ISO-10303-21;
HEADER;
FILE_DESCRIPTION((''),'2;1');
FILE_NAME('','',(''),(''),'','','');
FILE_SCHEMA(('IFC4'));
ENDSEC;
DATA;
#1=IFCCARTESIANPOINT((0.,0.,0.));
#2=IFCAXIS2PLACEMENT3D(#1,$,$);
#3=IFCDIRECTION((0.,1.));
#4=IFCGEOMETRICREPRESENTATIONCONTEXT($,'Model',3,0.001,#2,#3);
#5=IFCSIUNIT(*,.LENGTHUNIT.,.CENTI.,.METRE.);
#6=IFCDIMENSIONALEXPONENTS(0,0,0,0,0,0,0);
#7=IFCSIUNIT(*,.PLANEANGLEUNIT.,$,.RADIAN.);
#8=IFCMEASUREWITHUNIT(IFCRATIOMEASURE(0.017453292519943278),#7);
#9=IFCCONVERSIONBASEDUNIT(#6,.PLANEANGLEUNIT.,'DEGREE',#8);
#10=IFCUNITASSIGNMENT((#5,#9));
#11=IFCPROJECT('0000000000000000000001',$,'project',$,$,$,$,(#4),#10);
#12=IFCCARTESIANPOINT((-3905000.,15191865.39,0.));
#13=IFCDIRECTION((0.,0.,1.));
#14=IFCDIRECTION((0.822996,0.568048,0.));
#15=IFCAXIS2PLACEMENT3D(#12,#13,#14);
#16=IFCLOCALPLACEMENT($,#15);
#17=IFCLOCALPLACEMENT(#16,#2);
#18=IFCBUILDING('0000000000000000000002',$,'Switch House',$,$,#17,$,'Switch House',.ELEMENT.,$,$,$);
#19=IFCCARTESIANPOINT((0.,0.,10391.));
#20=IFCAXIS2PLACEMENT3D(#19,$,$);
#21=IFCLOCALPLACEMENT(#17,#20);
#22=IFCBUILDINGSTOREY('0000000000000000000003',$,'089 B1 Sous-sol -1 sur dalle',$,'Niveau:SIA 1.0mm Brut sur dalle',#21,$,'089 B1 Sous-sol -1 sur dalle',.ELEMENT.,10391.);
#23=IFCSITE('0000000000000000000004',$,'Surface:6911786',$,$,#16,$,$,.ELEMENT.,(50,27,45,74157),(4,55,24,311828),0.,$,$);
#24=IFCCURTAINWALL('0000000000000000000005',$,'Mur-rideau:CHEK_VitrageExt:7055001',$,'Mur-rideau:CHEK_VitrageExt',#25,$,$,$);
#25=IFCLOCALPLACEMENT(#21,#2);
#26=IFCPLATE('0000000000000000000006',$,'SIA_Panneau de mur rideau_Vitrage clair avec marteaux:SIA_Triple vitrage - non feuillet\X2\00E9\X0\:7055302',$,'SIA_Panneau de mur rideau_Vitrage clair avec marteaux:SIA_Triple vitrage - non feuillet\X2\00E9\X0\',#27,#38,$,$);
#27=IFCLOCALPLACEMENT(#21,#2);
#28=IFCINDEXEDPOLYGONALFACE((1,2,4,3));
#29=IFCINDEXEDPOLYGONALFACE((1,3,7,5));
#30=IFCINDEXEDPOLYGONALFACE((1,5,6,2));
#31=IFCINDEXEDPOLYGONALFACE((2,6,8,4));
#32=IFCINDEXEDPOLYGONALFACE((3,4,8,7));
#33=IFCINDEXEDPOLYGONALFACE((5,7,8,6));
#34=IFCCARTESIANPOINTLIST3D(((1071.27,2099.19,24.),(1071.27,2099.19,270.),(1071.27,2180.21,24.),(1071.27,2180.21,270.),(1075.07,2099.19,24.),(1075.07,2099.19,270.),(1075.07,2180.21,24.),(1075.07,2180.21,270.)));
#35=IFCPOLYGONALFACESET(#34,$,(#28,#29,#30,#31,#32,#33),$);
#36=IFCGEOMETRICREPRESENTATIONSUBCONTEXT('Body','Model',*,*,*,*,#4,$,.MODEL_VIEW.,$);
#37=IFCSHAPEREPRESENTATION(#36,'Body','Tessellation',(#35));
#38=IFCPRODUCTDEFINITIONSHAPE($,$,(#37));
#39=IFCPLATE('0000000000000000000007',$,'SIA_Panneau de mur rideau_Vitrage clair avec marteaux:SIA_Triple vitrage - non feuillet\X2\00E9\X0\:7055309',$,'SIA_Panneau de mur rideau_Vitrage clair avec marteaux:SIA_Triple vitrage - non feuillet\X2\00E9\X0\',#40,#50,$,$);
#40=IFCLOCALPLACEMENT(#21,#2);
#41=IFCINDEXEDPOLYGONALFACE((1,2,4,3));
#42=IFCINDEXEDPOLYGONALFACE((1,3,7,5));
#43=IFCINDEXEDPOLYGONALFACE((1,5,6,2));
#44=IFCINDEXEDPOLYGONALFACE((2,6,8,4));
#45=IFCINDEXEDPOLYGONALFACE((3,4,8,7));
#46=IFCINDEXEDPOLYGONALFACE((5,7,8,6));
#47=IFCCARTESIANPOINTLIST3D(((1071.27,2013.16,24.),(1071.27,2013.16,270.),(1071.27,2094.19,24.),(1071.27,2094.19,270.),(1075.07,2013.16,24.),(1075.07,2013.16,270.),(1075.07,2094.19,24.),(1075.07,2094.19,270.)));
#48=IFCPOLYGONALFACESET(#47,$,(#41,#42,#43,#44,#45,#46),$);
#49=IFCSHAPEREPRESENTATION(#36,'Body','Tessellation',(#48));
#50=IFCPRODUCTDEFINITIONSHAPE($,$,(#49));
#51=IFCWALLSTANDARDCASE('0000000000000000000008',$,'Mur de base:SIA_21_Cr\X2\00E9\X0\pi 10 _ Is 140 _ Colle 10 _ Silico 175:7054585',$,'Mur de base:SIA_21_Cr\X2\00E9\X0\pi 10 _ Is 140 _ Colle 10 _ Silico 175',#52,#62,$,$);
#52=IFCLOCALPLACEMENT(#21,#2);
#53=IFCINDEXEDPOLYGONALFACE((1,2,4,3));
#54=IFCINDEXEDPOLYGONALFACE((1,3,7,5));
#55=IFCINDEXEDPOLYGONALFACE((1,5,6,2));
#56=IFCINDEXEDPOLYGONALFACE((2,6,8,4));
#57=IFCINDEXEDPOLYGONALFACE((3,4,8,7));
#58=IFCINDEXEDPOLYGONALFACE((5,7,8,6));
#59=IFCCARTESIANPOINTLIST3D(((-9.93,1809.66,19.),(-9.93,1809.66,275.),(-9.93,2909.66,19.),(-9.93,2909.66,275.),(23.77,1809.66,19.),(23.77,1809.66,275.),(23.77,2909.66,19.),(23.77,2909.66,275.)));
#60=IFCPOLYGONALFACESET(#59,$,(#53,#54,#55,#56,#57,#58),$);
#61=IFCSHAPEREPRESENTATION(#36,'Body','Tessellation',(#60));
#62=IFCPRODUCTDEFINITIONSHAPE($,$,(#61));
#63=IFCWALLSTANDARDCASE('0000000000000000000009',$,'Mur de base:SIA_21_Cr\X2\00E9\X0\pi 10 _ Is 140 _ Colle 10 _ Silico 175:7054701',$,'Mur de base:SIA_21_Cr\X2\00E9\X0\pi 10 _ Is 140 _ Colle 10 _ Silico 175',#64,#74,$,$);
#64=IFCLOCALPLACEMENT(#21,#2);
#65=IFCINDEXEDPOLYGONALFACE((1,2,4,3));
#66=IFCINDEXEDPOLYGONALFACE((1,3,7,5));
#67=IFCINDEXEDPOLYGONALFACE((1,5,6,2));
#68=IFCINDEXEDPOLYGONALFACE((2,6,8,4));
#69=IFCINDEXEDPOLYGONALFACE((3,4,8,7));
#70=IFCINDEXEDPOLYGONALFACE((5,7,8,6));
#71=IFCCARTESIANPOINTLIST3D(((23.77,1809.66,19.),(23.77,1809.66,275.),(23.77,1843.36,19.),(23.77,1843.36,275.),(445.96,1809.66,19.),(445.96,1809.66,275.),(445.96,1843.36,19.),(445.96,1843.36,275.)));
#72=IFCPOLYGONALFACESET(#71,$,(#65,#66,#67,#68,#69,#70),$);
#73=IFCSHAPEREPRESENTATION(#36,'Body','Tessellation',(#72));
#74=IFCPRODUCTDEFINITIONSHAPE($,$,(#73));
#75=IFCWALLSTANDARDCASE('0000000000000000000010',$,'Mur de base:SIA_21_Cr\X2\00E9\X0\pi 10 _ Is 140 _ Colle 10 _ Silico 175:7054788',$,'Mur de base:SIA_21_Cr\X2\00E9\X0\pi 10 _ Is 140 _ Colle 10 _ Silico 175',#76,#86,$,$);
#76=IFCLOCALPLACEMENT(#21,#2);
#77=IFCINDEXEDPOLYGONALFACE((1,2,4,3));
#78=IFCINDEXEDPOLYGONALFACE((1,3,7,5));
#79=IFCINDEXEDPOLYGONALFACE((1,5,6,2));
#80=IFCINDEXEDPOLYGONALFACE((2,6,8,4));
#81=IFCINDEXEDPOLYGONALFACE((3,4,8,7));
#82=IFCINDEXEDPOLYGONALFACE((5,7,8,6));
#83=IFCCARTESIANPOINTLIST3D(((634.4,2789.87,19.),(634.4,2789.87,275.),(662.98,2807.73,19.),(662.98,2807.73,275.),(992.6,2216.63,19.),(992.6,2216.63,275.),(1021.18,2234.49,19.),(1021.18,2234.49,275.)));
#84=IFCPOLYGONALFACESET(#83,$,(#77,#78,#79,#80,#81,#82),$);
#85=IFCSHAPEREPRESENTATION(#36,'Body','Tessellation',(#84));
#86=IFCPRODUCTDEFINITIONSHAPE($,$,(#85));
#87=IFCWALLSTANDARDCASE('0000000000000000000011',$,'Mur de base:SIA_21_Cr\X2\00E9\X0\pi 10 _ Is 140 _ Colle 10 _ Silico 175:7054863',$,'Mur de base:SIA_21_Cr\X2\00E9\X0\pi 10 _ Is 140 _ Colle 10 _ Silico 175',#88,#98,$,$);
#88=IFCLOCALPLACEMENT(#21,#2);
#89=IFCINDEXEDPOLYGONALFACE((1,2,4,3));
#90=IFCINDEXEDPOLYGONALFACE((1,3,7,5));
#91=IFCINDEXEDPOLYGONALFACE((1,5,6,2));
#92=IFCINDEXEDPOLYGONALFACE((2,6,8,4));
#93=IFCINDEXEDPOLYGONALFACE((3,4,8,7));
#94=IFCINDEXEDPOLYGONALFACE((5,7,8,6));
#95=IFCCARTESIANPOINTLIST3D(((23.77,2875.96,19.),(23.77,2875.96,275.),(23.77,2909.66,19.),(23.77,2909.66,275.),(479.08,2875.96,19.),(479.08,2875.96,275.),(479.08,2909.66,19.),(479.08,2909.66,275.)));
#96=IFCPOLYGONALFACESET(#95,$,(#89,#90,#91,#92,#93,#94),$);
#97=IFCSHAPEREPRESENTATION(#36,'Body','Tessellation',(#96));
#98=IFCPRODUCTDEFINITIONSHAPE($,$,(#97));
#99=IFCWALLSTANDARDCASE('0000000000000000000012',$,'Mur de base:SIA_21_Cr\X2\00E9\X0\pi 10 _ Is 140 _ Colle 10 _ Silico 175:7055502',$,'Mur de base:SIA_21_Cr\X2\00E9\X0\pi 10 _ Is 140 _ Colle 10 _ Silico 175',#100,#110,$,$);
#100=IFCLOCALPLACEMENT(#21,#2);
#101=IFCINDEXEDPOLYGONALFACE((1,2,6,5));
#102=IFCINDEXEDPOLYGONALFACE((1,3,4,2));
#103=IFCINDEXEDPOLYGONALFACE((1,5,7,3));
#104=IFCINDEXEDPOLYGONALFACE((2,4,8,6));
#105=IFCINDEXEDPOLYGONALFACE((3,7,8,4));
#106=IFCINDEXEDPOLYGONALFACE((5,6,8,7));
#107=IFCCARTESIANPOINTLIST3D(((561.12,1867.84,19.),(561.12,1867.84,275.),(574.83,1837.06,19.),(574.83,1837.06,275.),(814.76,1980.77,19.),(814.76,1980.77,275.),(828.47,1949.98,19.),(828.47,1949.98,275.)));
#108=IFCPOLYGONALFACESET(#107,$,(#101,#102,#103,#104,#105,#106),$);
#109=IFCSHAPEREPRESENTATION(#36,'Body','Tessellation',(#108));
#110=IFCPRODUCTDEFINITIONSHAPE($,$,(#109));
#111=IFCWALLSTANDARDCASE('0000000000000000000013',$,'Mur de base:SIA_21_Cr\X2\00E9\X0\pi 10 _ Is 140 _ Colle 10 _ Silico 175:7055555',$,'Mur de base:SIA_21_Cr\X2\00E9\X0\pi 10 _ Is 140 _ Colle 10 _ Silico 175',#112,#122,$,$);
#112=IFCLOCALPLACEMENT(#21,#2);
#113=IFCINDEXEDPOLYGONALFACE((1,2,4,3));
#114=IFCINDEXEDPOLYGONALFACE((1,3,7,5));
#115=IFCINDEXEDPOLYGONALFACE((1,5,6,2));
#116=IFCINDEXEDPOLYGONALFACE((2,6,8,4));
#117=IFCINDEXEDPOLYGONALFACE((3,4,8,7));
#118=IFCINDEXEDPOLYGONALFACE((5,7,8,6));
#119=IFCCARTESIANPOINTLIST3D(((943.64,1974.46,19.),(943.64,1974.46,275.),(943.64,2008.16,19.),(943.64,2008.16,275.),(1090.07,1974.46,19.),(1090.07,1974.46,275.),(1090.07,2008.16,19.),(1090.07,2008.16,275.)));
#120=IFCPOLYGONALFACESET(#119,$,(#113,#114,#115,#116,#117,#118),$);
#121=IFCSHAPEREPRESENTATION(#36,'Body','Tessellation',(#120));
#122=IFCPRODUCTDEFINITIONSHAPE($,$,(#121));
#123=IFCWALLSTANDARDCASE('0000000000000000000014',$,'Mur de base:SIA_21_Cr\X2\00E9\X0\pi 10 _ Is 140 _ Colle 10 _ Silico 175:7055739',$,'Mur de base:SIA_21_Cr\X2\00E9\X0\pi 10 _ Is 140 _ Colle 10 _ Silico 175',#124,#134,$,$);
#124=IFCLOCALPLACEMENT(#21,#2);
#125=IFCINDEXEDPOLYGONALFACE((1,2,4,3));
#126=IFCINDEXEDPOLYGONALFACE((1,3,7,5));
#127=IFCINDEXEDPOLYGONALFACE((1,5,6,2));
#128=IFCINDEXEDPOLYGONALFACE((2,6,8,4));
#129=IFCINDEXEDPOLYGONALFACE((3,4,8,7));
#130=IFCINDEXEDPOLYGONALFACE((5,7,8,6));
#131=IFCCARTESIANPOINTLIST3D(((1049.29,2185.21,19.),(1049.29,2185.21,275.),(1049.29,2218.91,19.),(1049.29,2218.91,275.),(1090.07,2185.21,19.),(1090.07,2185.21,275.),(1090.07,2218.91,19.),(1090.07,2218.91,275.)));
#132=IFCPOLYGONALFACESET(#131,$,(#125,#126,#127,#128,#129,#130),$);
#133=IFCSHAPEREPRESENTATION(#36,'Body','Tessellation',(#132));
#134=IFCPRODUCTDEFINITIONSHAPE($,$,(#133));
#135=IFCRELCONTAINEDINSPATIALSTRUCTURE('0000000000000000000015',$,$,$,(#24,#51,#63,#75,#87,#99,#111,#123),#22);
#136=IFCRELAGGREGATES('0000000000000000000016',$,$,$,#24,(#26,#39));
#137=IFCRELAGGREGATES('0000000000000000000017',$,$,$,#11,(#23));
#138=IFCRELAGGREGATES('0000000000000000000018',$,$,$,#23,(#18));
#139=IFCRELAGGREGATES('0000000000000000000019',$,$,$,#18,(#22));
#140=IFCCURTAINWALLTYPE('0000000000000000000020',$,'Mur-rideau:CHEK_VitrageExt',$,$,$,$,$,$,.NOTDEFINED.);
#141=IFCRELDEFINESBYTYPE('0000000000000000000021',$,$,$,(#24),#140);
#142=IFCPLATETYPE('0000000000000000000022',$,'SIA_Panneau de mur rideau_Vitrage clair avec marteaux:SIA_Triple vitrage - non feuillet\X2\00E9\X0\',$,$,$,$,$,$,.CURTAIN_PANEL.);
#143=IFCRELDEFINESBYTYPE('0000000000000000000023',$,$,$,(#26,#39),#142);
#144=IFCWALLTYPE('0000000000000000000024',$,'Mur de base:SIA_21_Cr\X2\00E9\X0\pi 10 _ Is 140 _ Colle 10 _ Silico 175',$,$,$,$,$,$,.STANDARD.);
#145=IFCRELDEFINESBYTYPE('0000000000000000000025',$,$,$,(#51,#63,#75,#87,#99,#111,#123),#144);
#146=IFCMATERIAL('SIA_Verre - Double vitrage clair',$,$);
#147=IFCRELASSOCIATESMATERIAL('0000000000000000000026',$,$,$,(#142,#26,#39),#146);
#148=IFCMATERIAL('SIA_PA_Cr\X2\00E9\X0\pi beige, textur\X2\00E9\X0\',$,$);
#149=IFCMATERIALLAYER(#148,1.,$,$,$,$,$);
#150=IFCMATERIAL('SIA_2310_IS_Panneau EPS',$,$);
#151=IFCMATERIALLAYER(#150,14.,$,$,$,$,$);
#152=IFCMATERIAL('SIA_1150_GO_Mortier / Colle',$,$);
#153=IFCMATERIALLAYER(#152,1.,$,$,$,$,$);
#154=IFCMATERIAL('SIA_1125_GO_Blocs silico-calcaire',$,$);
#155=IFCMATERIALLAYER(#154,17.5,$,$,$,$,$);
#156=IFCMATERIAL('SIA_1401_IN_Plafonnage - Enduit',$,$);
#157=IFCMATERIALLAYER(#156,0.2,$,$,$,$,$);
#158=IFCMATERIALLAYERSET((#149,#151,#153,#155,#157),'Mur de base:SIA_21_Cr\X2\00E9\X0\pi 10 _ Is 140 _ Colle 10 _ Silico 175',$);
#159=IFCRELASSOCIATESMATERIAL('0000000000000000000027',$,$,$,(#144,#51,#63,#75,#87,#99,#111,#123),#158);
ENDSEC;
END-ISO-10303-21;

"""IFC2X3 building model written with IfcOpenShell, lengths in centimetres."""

from ifc_helpers import new_model, entity, si_unit, converted_unit, direction, frame, frame_2d, origin, origin_2d_with_axis, place, context, subcontext, project, spatial, rectangle, extrude, source, transform, mapped, material, layer, layer_set, layer_usage, type_object, type_shapes, element, aggregate, save


model = new_model("IFC2X3")

# Units and contexts
model_context = context("Model", 3, precision=0.001, world=origin(), true_north=direction((0.0, 1.0)))
body_context = subcontext(model_context, "Body", "Model", "MODEL_VIEW")
ifc_project = project(units=[si_unit("LENGTHUNIT", "METRE", prefix="CENTI"), converted_unit("PLANEANGLEUNIT", "DEGREE", entity("IfcRatioMeasure", 0.017453292519943278), si_unit("PLANEANGLEUNIT", "RADIAN"), dimensions=[0, 0, 0, 0, 0, 0, 0])], contexts=[model_context])

# Site, building, storey
site_placement = place(None, frame((-3905000.0, 15191865.39, 0.0), z_axis=(0.0, 0.0, 1.0), x_axis=(0.822996, 0.568048, 0.0)))
site = spatial("IfcSite", under=ifc_project, at=site_placement, Name="Surface:6911786", CompositionType="ELEMENT", RefLatitude=(50, 27, 45, 74157), RefLongitude=(4, 55, 24, 311828), RefElevation=0.0)
building_placement = place(site_placement, origin())
building = spatial("IfcBuilding", under=site, at=building_placement, Name="Switch House", LongName="Switch House", CompositionType="ELEMENT")
storey_placement = place(building_placement, frame((0.0, 0.0, 10391.0)))
storey = spatial("IfcBuildingStorey", under=building, at=storey_placement, Name="089 B1 Sous-sol -1 sur dalle", ObjectType="Niveau:SIA 1.0mm Brut sur dalle", LongName="089 B1 Sous-sol -1 sur dalle", CompositionType="ELEMENT", Elevation=10391.0)

# Curtain wall, plates
curtain_wall_type = type_object("IfcCurtainWallType", Name="Mur-rideau:CHEK_VitrageExt", PredefinedType="NOTDEFINED")
curtain_wall_placement = place(storey_placement, frame((0.0, 0.0, -10391.0)))
curtain_wall = element("IfcCurtainWall", 1, at=curtain_wall_placement, inside=storey, type_object=curtain_wall_type, Name="Mur-rideau:CHEK_VitrageExt:7055001", ObjectType="Mur-rideau:CHEK_VitrageExt")
ifc_material_1 = material(Name="SIA_Verre - Double vitrage clair")
plate_type = type_object("IfcPlateType", Name="SIA_Panneau de mur rideau_Vitrage clair avec marteaux:SIA_Triple vitrage - non feuilleté", PredefinedType="CURTAIN_PANEL", material=ifc_material_1)
shared_shape_1 = source(origin(), body_context, "Body", "SweptSolid", [
    extrude(rectangle(XDim=3.8, YDim=81.02, at=origin_2d_with_axis()), frame((0.0, -1.9, 0.0), z_axis=(0.0, 0.0, 1.0), x_axis=(0.0, 1.0, 0.0)), (0.0, 0.0, 1.0), 246.0),
])
type_shapes(plate_type, [shared_shape_1])
plate_1_placement = place(curtain_wall_placement, frame((1075.07, 2139.7, 10415.0), z_axis=(0.0, 0.0, 1.0), x_axis=(0.0, -1.0, 0.0)))
plate_1 = element("IfcPlate", 2, at=plate_1_placement, type_object=plate_type, material=ifc_material_1, Name="SIA_Panneau de mur rideau_Vitrage clair avec marteaux:SIA_Triple vitrage - non feuilleté:7055302", ObjectType="SIA_Panneau de mur rideau_Vitrage clair avec marteaux:SIA_Triple vitrage - non feuilleté", context=body_context, shape_type="MappedRepresentation", body=[
    mapped(shared_shape_1, transform((0.0, 0.0, 0.0), scale=1.0)),
])
plate_2_placement = place(curtain_wall_placement, frame((1075.07, 2053.67, 10415.0), z_axis=(0.0, 0.0, 1.0), x_axis=(0.0, -1.0, 0.0)))
plate_2 = element("IfcPlate", 3, at=plate_2_placement, type_object=plate_type, material=ifc_material_1, Name="SIA_Panneau de mur rideau_Vitrage clair avec marteaux:SIA_Triple vitrage - non feuilleté:7055309", ObjectType="SIA_Panneau de mur rideau_Vitrage clair avec marteaux:SIA_Triple vitrage - non feuilleté", context=body_context, shape_type="MappedRepresentation", body=[
    mapped(shared_shape_1, transform((0.0, 0.0, 0.0), scale=1.0)),
])
aggregate(curtain_wall, [plate_1, plate_2])

# Walls
ifc_material_2 = material(Name="SIA_PA_Crépi beige, texturé")
ifc_layer_1 = layer(ifc_material_2, 1.0)
ifc_material_3 = material(Name="SIA_2310_IS_Panneau EPS")
ifc_layer_2 = layer(ifc_material_3, 14.0)
ifc_material_4 = material(Name="SIA_1150_GO_Mortier / Colle")
ifc_layer_3 = layer(ifc_material_4, 1.0)
ifc_material_5 = material(Name="SIA_1125_GO_Blocs silico-calcaire")
ifc_layer_4 = layer(ifc_material_5, 17.5)
ifc_material_6 = material(Name="SIA_1401_IN_Plafonnage - Enduit")
ifc_layer_5 = layer(ifc_material_6, 0.2)
ifc_layer_set = layer_set([ifc_layer_1, ifc_layer_2, ifc_layer_3, ifc_layer_4, ifc_layer_5], Name="Mur de base:SIA_21_Crépi 10 _ Is 140 _ Colle 10 _ Silico 175")
ifc_layer_usage_1 = layer_usage(ifc_layer_set, "AXIS2", "POSITIVE", -16.85)
wall_type = type_object("IfcWallType", Name="Mur de base:SIA_21_Crépi 10 _ Is 140 _ Colle 10 _ Silico 175", PredefinedType="STANDARD", material=ifc_layer_set)
wall_1_placement = place(storey_placement, frame((6.92, 2909.66, 19.0), z_axis=(0.0, 0.0, 1.0), x_axis=(0.0, -1.0, 0.0)))
element("IfcWallStandardCase", 4, at=wall_1_placement, inside=storey, type_object=wall_type, material=ifc_layer_usage_1, Name="Mur de base:SIA_21_Crépi 10 _ Is 140 _ Colle 10 _ Silico 175:7054585", ObjectType="Mur de base:SIA_21_Crépi 10 _ Is 140 _ Colle 10 _ Silico 175", context=body_context, shape_type="SweptSolid", body=[
    extrude(rectangle(XDim=1100.0, YDim=33.7, at=frame_2d((550.0, 0.0), x_axis=(-1.0, 0.0))), origin(), (0.0, 0.0, 1.0), 256.0),
])
wall_2_placement = place(storey_placement, frame((23.77, 1826.51, 19.0)))
element("IfcWallStandardCase", 5, at=wall_2_placement, inside=storey, type_object=wall_type, material=ifc_layer_usage_1, Name="Mur de base:SIA_21_Crépi 10 _ Is 140 _ Colle 10 _ Silico 175:7054701", ObjectType="Mur de base:SIA_21_Crépi 10 _ Is 140 _ Colle 10 _ Silico 175", context=body_context, shape_type="SweptSolid", body=[
    extrude(rectangle(XDim=422.19, YDim=33.7, at=frame_2d((211.09, 0.0), x_axis=(-1.0, 0.0))), origin(), (0.0, 0.0, 1.0), 256.0),
])
wall_3_placement = place(storey_placement, frame((1006.89, 2225.56, 19.0), z_axis=(0.0, 0.0, 1.0), x_axis=(-0.529919, 0.848048, 0.0)))
element("IfcWallStandardCase", 6, at=wall_3_placement, inside=storey, type_object=wall_type, material=ifc_layer_usage_1, Name="Mur de base:SIA_21_Crépi 10 _ Is 140 _ Colle 10 _ Silico 175:7054788", ObjectType="Mur de base:SIA_21_Crépi 10 _ Is 140 _ Colle 10 _ Silico 175", context=body_context, shape_type="SweptSolid", body=[
    extrude(rectangle(XDim=675.94, YDim=33.7, at=frame_2d((337.97, 0.0), x_axis=(-1.0, 0.0))), origin(), (0.0, 0.0, 1.0), 256.0),
])
wall_4_placement = place(storey_placement, frame((479.08, 2892.81, 19.0), z_axis=(0.0, 0.0, 1.0), x_axis=(-1.0, 0.0, 0.0)))
element("IfcWallStandardCase", 7, at=wall_4_placement, inside=storey, type_object=wall_type, material=ifc_layer_usage_1, Name="Mur de base:SIA_21_Crépi 10 _ Is 140 _ Colle 10 _ Silico 175:7054863", ObjectType="Mur de base:SIA_21_Crépi 10 _ Is 140 _ Colle 10 _ Silico 175", context=body_context, shape_type="SweptSolid", body=[
    extrude(rectangle(XDim=455.31, YDim=33.7, at=frame_2d((227.66, 0.0), x_axis=(-1.0, 0.0))), origin(), (0.0, 0.0, 1.0), 256.0),
])
wall_5_placement = place(storey_placement, frame((567.98, 1852.45, 19.0), z_axis=(0.0, 0.0, 1.0), x_axis=(0.913545, 0.406737, 0.0)))
element("IfcWallStandardCase", 8, at=wall_5_placement, inside=storey, type_object=wall_type, material=ifc_layer_usage_1, Name="Mur de base:SIA_21_Crépi 10 _ Is 140 _ Colle 10 _ Silico 175:7055502", ObjectType="Mur de base:SIA_21_Crépi 10 _ Is 140 _ Colle 10 _ Silico 175", context=body_context, shape_type="SweptSolid", body=[
    extrude(rectangle(XDim=277.64, YDim=33.7, at=frame_2d((138.82, 0.0), x_axis=(-1.0, 0.0))), origin(), (0.0, 0.0, 1.0), 256.0),
])
wall_6_placement = place(storey_placement, frame((943.64, 1991.31, 19.0)))
element("IfcWallStandardCase", 9, at=wall_6_placement, inside=storey, type_object=wall_type, material=ifc_layer_usage_1, Name="Mur de base:SIA_21_Crépi 10 _ Is 140 _ Colle 10 _ Silico 175:7055555", ObjectType="Mur de base:SIA_21_Crépi 10 _ Is 140 _ Colle 10 _ Silico 175", context=body_context, shape_type="SweptSolid", body=[
    extrude(rectangle(XDim=146.43, YDim=33.7, at=frame_2d((73.22, 0.0), x_axis=(-1.0, 0.0))), origin(), (0.0, 0.0, 1.0), 256.0),
])
ifc_layer_usage_2 = layer_usage(ifc_layer_set, "AXIS2", "NEGATIVE", 16.85)
wall_7_placement = place(storey_placement, frame((1049.29, 2202.06, 19.0)))
element("IfcWallStandardCase", 10, at=wall_7_placement, inside=storey, type_object=wall_type, material=ifc_layer_usage_2, Name="Mur de base:SIA_21_Crépi 10 _ Is 140 _ Colle 10 _ Silico 175:7055739", ObjectType="Mur de base:SIA_21_Crépi 10 _ Is 140 _ Colle 10 _ Silico 175", context=body_context, shape_type="SweptSolid", body=[
    extrude(rectangle(XDim=40.78, YDim=33.7, at=frame_2d((20.39, 0.0), x_axis=(-1.0, 0.0))), origin(), (0.0, 0.0, 1.0), 256.0),
])

save(model, "model.ifc")
